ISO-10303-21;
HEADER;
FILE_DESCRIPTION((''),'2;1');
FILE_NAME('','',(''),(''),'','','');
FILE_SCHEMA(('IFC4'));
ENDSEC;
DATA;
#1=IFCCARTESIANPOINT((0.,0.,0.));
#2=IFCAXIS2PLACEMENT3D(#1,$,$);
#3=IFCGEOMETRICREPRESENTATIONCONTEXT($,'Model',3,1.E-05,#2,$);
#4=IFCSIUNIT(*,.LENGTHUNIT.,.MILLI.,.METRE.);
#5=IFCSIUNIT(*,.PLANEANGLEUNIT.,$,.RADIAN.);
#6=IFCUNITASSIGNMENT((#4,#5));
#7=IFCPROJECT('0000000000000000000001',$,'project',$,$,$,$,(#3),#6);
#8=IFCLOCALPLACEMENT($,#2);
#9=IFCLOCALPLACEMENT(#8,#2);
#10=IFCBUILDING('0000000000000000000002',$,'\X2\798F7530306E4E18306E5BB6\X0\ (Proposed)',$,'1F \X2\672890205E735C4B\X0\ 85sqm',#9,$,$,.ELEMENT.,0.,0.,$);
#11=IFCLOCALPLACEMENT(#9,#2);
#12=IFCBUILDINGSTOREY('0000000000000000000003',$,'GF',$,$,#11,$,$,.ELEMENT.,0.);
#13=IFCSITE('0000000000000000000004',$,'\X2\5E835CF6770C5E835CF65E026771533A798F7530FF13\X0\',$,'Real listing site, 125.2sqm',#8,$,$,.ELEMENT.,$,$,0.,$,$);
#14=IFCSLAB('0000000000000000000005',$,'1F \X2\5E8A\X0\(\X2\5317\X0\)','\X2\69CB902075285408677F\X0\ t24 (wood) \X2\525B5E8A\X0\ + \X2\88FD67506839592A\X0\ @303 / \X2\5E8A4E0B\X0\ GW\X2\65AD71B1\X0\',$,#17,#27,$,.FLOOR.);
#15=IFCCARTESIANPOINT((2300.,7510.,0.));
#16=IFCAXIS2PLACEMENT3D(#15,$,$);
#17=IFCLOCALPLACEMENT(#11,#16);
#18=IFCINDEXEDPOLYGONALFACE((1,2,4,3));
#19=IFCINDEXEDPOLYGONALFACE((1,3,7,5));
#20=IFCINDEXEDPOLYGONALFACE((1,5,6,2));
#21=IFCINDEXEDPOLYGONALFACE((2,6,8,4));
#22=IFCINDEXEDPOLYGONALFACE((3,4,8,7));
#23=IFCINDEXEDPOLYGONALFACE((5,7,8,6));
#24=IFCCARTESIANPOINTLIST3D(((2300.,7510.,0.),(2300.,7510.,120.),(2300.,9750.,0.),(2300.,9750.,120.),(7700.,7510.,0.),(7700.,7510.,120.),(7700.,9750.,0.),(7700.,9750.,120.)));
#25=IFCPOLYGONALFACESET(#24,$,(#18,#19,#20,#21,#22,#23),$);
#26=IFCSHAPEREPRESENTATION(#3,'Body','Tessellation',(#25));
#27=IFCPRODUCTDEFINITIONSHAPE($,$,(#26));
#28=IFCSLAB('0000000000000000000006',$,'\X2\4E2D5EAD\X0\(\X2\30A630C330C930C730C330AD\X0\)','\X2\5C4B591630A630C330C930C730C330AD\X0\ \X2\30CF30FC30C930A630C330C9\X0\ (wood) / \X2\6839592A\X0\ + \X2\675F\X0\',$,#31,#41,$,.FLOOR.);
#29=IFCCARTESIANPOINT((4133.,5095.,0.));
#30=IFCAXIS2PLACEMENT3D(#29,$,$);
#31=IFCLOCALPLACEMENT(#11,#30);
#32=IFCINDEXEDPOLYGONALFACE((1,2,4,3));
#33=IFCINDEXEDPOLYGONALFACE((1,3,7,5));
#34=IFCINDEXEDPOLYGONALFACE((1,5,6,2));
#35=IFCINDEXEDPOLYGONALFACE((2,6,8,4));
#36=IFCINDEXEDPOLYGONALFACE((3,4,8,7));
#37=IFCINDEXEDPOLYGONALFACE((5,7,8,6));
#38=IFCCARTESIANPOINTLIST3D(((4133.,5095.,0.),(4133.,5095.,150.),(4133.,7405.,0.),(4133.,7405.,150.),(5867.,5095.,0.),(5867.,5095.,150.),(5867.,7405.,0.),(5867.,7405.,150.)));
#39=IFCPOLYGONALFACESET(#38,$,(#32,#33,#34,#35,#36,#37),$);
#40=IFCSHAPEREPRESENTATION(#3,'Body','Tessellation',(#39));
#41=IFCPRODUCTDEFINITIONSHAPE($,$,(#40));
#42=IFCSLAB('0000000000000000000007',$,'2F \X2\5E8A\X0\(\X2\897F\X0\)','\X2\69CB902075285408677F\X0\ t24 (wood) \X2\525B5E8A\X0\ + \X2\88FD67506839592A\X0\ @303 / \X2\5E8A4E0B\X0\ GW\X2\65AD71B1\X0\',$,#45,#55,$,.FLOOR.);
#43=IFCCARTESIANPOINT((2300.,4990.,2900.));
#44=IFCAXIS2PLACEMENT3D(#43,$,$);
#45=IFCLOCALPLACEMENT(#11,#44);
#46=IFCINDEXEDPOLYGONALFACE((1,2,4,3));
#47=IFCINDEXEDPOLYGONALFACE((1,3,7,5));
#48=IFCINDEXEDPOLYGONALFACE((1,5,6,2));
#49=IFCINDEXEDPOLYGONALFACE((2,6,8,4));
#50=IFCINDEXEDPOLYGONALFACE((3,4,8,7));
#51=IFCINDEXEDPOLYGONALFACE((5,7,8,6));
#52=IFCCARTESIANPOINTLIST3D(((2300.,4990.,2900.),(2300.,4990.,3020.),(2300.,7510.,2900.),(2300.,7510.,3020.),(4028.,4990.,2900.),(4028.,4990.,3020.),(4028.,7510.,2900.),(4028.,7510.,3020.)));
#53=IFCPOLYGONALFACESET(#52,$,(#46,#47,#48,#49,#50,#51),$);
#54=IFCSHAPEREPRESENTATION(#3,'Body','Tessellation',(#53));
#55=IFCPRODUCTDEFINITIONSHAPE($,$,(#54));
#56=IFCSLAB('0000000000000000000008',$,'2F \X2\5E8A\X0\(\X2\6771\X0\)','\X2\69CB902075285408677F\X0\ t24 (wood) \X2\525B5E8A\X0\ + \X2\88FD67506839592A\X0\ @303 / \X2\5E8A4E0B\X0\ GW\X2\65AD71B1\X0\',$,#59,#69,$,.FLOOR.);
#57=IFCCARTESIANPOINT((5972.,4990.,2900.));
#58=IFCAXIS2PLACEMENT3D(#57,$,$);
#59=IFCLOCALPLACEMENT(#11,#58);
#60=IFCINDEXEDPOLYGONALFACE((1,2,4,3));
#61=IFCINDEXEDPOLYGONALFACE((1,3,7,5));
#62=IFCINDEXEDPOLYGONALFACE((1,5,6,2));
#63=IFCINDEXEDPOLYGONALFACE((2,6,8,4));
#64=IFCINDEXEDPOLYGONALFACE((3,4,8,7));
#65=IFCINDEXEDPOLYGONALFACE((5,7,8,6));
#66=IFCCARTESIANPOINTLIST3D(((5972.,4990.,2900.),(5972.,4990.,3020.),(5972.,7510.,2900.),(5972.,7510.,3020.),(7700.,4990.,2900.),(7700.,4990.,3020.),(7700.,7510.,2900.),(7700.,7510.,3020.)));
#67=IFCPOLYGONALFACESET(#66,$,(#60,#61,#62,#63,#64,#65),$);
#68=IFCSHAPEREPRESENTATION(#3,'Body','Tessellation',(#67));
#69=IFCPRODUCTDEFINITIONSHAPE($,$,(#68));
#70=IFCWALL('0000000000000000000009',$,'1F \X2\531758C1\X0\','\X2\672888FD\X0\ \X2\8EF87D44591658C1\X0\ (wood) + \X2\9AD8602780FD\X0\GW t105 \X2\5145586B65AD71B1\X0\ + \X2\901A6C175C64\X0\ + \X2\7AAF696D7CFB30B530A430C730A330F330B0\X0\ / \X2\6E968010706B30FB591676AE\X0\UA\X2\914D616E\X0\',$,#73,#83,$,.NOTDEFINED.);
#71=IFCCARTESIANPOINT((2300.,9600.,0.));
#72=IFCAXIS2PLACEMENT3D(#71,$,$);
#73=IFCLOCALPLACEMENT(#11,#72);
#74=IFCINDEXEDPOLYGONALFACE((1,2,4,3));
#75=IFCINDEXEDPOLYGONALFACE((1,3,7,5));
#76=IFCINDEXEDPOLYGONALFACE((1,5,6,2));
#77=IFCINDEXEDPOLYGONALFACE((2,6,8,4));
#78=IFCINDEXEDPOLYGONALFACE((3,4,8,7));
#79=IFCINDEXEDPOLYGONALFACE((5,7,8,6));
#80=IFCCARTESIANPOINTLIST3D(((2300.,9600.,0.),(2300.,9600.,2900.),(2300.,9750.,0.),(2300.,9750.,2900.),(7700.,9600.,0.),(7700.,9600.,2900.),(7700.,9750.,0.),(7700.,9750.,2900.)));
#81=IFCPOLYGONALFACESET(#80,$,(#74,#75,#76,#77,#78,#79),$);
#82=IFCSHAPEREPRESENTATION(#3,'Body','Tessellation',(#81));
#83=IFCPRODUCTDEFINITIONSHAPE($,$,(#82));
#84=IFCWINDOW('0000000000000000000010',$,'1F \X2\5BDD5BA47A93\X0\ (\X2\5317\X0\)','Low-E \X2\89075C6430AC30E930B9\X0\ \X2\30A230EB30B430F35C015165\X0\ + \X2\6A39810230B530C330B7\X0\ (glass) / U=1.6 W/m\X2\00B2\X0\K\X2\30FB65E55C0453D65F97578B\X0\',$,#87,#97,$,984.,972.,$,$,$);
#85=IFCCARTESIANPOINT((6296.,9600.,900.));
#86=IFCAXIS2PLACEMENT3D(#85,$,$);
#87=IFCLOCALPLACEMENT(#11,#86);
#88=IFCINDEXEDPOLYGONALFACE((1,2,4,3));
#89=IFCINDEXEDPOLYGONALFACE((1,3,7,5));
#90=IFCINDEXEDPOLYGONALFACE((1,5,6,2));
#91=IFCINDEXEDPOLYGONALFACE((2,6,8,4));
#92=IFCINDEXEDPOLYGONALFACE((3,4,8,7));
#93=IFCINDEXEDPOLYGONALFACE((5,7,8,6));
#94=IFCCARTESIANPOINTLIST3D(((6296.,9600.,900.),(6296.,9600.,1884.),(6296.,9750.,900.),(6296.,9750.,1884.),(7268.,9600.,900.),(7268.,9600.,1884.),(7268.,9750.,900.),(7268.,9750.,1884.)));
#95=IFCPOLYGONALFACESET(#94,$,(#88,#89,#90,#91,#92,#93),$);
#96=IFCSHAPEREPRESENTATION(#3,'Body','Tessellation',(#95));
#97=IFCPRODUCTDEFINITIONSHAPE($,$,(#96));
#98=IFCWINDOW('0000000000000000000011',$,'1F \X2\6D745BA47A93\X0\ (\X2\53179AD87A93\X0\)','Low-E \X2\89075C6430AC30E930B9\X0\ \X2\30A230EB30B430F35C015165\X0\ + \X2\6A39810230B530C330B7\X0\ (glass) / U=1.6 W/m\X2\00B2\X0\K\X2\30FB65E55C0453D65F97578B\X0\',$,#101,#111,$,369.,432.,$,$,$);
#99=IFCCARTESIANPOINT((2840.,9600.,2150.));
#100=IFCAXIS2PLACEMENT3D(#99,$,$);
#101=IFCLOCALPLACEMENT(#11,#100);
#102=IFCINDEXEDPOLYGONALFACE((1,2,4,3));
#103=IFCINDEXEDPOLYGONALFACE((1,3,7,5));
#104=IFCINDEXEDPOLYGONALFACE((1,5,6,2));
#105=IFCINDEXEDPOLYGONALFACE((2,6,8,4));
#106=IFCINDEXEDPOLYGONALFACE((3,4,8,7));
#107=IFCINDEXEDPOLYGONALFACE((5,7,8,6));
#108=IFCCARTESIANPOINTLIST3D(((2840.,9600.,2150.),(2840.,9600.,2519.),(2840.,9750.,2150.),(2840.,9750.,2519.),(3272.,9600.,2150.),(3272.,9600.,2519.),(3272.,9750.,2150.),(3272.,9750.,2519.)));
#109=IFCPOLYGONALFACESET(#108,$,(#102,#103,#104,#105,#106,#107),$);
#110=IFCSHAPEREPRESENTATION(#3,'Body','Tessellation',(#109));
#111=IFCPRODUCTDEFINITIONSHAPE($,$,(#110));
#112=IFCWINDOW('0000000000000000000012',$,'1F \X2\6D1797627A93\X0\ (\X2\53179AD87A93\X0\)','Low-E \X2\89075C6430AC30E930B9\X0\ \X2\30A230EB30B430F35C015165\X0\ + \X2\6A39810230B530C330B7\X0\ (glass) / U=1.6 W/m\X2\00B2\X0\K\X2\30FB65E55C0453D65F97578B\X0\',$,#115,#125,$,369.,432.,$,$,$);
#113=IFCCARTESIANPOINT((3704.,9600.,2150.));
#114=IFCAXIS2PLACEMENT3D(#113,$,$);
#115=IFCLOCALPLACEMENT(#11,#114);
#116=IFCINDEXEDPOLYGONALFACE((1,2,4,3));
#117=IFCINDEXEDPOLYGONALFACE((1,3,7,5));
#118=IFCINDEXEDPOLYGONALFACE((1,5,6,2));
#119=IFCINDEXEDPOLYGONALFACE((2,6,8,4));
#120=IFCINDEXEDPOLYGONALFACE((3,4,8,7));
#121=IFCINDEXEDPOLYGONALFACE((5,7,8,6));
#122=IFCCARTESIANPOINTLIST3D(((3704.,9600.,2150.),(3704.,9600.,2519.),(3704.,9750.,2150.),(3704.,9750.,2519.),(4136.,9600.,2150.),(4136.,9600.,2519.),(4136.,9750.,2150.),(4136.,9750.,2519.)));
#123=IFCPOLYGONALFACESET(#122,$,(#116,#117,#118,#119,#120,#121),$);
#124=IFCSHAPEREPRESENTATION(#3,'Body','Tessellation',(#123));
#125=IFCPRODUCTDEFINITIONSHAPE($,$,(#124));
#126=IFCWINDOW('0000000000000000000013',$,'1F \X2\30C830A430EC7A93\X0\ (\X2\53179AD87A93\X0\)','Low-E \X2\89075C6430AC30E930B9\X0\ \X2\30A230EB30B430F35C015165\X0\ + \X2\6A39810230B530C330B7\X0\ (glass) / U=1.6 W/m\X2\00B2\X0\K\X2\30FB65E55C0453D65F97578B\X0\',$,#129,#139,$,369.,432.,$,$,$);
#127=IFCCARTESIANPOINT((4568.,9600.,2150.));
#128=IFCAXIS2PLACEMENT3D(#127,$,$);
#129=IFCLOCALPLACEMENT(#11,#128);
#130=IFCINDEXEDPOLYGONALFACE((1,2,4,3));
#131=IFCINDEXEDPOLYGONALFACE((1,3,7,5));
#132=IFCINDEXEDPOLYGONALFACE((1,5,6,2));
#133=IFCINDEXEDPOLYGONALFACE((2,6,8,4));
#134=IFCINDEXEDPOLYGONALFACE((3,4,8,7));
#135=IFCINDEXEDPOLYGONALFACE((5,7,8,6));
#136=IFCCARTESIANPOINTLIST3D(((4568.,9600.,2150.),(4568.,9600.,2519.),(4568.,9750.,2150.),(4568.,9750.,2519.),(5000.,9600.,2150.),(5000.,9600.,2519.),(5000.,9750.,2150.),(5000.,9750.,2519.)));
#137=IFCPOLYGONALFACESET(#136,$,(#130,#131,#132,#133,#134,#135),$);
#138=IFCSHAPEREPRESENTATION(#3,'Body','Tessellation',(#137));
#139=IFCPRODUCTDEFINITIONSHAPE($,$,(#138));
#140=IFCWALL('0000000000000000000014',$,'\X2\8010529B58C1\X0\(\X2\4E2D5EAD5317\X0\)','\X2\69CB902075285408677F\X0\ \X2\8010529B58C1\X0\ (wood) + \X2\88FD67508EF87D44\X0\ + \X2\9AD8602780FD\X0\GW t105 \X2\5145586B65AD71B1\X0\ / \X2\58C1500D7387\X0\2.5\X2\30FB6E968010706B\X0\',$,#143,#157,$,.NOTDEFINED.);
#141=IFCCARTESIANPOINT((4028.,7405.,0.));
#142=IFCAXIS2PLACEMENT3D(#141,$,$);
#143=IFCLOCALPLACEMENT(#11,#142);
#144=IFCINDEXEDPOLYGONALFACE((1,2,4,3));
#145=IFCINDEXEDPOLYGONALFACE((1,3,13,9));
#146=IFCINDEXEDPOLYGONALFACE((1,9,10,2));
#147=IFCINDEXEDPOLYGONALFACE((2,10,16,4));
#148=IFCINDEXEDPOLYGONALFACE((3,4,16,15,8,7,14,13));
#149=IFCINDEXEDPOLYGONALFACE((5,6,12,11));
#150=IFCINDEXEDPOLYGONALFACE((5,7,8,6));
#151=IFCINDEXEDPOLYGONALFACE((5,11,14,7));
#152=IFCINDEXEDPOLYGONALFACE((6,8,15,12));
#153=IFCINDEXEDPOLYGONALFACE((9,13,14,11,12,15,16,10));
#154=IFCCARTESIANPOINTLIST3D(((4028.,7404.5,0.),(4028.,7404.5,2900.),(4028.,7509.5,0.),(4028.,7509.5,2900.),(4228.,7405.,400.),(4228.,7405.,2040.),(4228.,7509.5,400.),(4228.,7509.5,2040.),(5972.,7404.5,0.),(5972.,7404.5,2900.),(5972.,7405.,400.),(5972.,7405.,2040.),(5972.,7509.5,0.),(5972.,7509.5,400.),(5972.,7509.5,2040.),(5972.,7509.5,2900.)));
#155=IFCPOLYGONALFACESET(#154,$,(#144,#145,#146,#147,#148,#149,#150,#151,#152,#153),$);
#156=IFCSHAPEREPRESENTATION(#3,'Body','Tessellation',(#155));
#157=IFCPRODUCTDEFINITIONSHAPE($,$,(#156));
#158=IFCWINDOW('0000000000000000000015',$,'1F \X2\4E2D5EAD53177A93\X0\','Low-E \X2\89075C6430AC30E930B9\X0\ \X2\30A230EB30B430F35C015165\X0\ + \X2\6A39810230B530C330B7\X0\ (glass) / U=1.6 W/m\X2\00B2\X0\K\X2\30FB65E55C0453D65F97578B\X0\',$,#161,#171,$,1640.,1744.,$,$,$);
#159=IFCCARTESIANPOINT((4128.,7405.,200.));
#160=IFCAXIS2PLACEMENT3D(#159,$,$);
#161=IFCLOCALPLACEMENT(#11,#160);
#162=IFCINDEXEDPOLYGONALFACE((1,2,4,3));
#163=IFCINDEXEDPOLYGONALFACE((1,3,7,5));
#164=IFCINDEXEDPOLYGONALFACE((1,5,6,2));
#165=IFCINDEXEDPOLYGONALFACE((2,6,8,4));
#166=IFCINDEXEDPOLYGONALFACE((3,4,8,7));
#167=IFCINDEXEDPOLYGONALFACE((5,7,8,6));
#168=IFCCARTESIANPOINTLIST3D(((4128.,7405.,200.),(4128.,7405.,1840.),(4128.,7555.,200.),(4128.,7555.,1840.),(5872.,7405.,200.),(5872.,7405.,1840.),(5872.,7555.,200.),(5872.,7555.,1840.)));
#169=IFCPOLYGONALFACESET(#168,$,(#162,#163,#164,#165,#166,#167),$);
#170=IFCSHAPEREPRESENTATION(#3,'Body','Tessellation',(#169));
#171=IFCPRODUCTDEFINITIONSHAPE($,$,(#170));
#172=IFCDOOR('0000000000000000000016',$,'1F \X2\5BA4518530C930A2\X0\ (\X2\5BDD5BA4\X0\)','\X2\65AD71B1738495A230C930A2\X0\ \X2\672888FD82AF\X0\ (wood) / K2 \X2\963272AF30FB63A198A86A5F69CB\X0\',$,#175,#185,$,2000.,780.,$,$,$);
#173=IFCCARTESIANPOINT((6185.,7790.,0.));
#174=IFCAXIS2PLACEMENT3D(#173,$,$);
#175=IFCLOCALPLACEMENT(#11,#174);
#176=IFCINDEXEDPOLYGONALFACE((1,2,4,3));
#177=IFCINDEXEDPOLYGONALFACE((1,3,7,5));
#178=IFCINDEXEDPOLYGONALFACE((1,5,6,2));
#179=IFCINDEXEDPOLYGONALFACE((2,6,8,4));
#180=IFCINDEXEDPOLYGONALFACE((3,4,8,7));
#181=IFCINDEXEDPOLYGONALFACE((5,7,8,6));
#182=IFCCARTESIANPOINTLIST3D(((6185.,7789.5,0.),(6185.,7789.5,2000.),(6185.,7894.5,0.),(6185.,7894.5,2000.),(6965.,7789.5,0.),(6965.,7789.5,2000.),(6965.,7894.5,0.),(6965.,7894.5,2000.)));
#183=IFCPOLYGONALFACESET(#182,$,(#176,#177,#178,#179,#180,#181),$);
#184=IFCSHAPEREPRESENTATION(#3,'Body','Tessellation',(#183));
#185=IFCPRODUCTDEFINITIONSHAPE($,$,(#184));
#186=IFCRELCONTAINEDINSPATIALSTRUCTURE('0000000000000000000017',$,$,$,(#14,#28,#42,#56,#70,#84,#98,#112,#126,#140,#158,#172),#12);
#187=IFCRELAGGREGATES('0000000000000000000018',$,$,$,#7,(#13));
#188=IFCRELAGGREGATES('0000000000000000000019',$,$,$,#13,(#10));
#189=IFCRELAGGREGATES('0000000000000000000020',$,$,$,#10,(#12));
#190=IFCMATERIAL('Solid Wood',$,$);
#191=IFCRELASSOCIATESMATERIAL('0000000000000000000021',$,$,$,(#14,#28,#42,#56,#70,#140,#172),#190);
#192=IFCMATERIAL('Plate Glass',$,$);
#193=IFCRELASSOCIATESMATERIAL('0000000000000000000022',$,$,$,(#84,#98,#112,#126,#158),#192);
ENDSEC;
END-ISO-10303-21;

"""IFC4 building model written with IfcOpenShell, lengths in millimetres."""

from ifc_helpers import new_model, si_unit, frame, frame_2d, origin, place, context, project, spatial, rectangle, extrude, material, element, fill, save


model = new_model("IFC4")

# Units and contexts
model_context = context("Model", 3, precision=1e-05, world=origin())
ifc_project = project(units=[si_unit("LENGTHUNIT", "METRE", prefix="MILLI"), si_unit("PLANEANGLEUNIT", "RADIAN")], contexts=[model_context])

# Site, building, storey
site_placement = place(None, origin())
site = spatial("IfcSite", under=ifc_project, at=site_placement, Name="広島県広島市東区福田３", ObjectType="Real listing site, 125.2sqm", CompositionType="ELEMENT", RefElevation=0.0)
building_placement = place(site_placement, origin())
building = spatial("IfcBuilding", under=site, at=building_placement, Name="福田の丘の家 (Proposed)", ObjectType="1F 木造平屋 85sqm", CompositionType="ELEMENT", ElevationOfRefHeight=0.0, ElevationOfTerrain=0.0)
storey_placement = place(building_placement, origin())
storey = spatial("IfcBuildingStorey", under=building, at=storey_placement, Name="GF", CompositionType="ELEMENT", Elevation=0.0)

# Slabs
ifc_material_1 = material(Name="Solid Wood")
slab_1_placement = place(storey_placement, frame((2300.0, 7510.0, 0.0)))
element("IfcSlab", 1, at=slab_1_placement, inside=storey, material=ifc_material_1, Name="1F 床(北)", Description="構造用合板 t24 (wood) 剛床 + 製材根太 @303 / 床下 GW断熱", PredefinedType="FLOOR", context=model_context, shape_type="SweptSolid", body=[
    extrude(rectangle(XDim=5400.0, YDim=2240.0, at=frame_2d((2700.0, 1120.0))), frame((2300.0, 7510.0, 0.0)), (0.0, 0.0, 1.0), 120.0),
])
slab_2_placement = place(storey_placement, frame((4133.0, 5095.0, 0.0)))
element("IfcSlab", 2, at=slab_2_placement, inside=storey, material=ifc_material_1, Name="中庭(ウッドデッキ)", Description="屋外ウッドデッキ ハードウッド (wood) / 根太 + 束", PredefinedType="FLOOR", context=model_context, shape_type="SweptSolid", body=[
    extrude(rectangle(XDim=1734.0, YDim=2310.0, at=frame_2d((867.0, 1155.0))), frame((4133.0, 5095.0, 0.0)), (0.0, 0.0, 1.0), 150.0),
])
slab_3_placement = place(storey_placement, frame((2300.0, 4990.0, 2900.0)))
element("IfcSlab", 3, at=slab_3_placement, inside=storey, material=ifc_material_1, Name="2F 床(西)", Description="構造用合板 t24 (wood) 剛床 + 製材根太 @303 / 床下 GW断熱", PredefinedType="FLOOR", context=model_context, shape_type="SweptSolid", body=[
    extrude(rectangle(XDim=1728.0, YDim=2520.0, at=frame_2d((864.0, 1260.0))), frame((2300.0, 4990.0, 2900.0)), (0.0, 0.0, 1.0), 120.0),
])
slab_4_placement = place(storey_placement, frame((5972.0, 4990.0, 2900.0)))
element("IfcSlab", 4, at=slab_4_placement, inside=storey, material=ifc_material_1, Name="2F 床(東)", Description="構造用合板 t24 (wood) 剛床 + 製材根太 @303 / 床下 GW断熱", PredefinedType="FLOOR", context=model_context, shape_type="SweptSolid", body=[
    extrude(rectangle(XDim=1728.0, YDim=2520.0, at=frame_2d((864.0, 1260.0))), frame((5972.0, 4990.0, 2900.0)), (0.0, 0.0, 1.0), 120.0),
])

# Wall, openings, windows
wall_1_placement = place(storey_placement, frame((2300.0, 9600.0, 0.0)))
wall_1 = element("IfcWall", 5, at=wall_1_placement, inside=storey, material=ifc_material_1, Name="1F 北壁", Description="木製 軸組外壁 (wood) + 高性能GW t105 充填断熱 + 通気層 + 窯業系サイディング / 準耐火・外皮UA配慮", PredefinedType="NOTDEFINED", context=model_context, shape_type="SweptSolid", body=[
    extrude(rectangle(XDim=5400.0, YDim=150.0, at=frame_2d((2700.0, 75.0))), frame((2300.0, 9600.0, 0.0)), (0.0, 0.0, 1.0), 2900.0),
])
opening_1_placement = place(storey_placement, frame((6296.0, 9600.0, 900.0)))
opening_1 = element("IfcOpeningElement", 6, at=opening_1_placement, cuts=wall_1, PredefinedType="NOTDEFINED", context=model_context, shape_type="SweptSolid", body=[
    extrude(rectangle(XDim=972.0, YDim=150.0, at=frame_2d((486.0, 75.0))), frame((6296.0, 9600.0, 900.0)), (0.0, 0.0, 1.0), 984.0),
])
opening_2_placement = place(storey_placement, frame((2840.0, 9600.0, 2150.0)))
opening_2 = element("IfcOpeningElement", 7, at=opening_2_placement, cuts=wall_1, PredefinedType="NOTDEFINED", context=model_context, shape_type="SweptSolid", body=[
    extrude(rectangle(XDim=432.0, YDim=150.0, at=frame_2d((216.0, 75.0))), frame((2840.0, 9600.0, 2150.0)), (0.0, 0.0, 1.0), 369.0),
])
opening_3_placement = place(storey_placement, frame((3704.0, 9600.0, 2150.0)))
opening_3 = element("IfcOpeningElement", 8, at=opening_3_placement, cuts=wall_1, PredefinedType="NOTDEFINED", context=model_context, shape_type="SweptSolid", body=[
    extrude(rectangle(XDim=432.0, YDim=150.0, at=frame_2d((216.0, 75.0))), frame((3704.0, 9600.0, 2150.0)), (0.0, 0.0, 1.0), 369.0),
])
opening_4_placement = place(storey_placement, frame((4568.0, 9600.0, 2150.0)))
opening_4 = element("IfcOpeningElement", 9, at=opening_4_placement, cuts=wall_1, PredefinedType="NOTDEFINED", context=model_context, shape_type="SweptSolid", body=[
    extrude(rectangle(XDim=432.0, YDim=150.0, at=frame_2d((216.0, 75.0))), frame((4568.0, 9600.0, 2150.0)), (0.0, 0.0, 1.0), 369.0),
])
ifc_material_2 = material(Name="Plate Glass")
window_1_placement = place(storey_placement, frame((6296.0, 9600.0, 900.0)))
window_1 = element("IfcWindow", 10, at=window_1_placement, inside=storey, material=ifc_material_2, Name="1F 寝室窓 (北)", Description="Low-E 複層ガラス アルゴン封入 + 樹脂サッシ (glass) / U=1.6 W/m²K・日射取得型", OverallHeight=984.0, OverallWidth=972.0, context=model_context, shape_type="SweptSolid", body=[
    extrude(rectangle(XDim=972.0, YDim=150.0, at=frame_2d((486.0, 75.0))), frame((6296.0, 9600.0, 900.0)), (0.0, 0.0, 1.0), 984.0),
])
fill(opening_1, window_1)
window_2_placement = place(storey_placement, frame((2840.0, 9600.0, 2150.0)))
window_2 = element("IfcWindow", 11, at=window_2_placement, inside=storey, material=ifc_material_2, Name="1F 浴室窓 (北高窓)", Description="Low-E 複層ガラス アルゴン封入 + 樹脂サッシ (glass) / U=1.6 W/m²K・日射取得型", OverallHeight=369.0, OverallWidth=432.0, context=model_context, shape_type="SweptSolid", body=[
    extrude(rectangle(XDim=432.0, YDim=150.0, at=frame_2d((216.0, 75.0))), frame((2840.0, 9600.0, 2150.0)), (0.0, 0.0, 1.0), 369.0),
])
fill(opening_2, window_2)
window_3_placement = place(storey_placement, frame((3704.0, 9600.0, 2150.0)))
window_3 = element("IfcWindow", 12, at=window_3_placement, inside=storey, material=ifc_material_2, Name="1F 洗面窓 (北高窓)", Description="Low-E 複層ガラス アルゴン封入 + 樹脂サッシ (glass) / U=1.6 W/m²K・日射取得型", OverallHeight=369.0, OverallWidth=432.0, context=model_context, shape_type="SweptSolid", body=[
    extrude(rectangle(XDim=432.0, YDim=150.0, at=frame_2d((216.0, 75.0))), frame((3704.0, 9600.0, 2150.0)), (0.0, 0.0, 1.0), 369.0),
])
fill(opening_3, window_3)
window_4_placement = place(storey_placement, frame((4568.0, 9600.0, 2150.0)))
window_4 = element("IfcWindow", 13, at=window_4_placement, inside=storey, material=ifc_material_2, Name="1F トイレ窓 (北高窓)", Description="Low-E 複層ガラス アルゴン封入 + 樹脂サッシ (glass) / U=1.6 W/m²K・日射取得型", OverallHeight=369.0, OverallWidth=432.0, context=model_context, shape_type="SweptSolid", body=[
    extrude(rectangle(XDim=432.0, YDim=150.0, at=frame_2d((216.0, 75.0))), frame((4568.0, 9600.0, 2150.0)), (0.0, 0.0, 1.0), 369.0),
])
fill(opening_4, window_4)

# Wall, opening, window
wall_2_placement = place(storey_placement, frame((4028.0, 7405.0, 0.0)))
wall_2 = element("IfcWall", 14, at=wall_2_placement, inside=storey, material=ifc_material_1, Name="耐力壁(中庭北)", Description="構造用合板 耐力壁 (wood) + 製材軸組 + 高性能GW t105 充填断熱 / 壁倍率2.5・準耐火", PredefinedType="NOTDEFINED", context=model_context, shape_type="SweptSolid", body=[
    extrude(rectangle(XDim=1944.0, YDim=105.0, at=frame_2d((972.0, 52.0))), frame((4028.0, 7405.0, 0.0)), (0.0, 0.0, 1.0), 2900.0),
])
opening_5_placement = place(storey_placement, frame((4128.0, 7405.0, 200.0)))
opening_5 = element("IfcOpeningElement", 15, at=opening_5_placement, cuts=wall_2, PredefinedType="NOTDEFINED", context=model_context, shape_type="SweptSolid", body=[
    extrude(rectangle(XDim=1744.0, YDim=150.0, at=frame_2d((872.0, 75.0))), frame((4128.0, 7405.0, 200.0)), (0.0, 0.0, 1.0), 1640.0),
])
window_5_placement = place(storey_placement, frame((4128.0, 7405.0, 200.0)))
window_5 = element("IfcWindow", 16, at=window_5_placement, inside=storey, material=ifc_material_2, Name="1F 中庭北窓", Description="Low-E 複層ガラス アルゴン封入 + 樹脂サッシ (glass) / U=1.6 W/m²K・日射取得型", OverallHeight=1640.0, OverallWidth=1744.0, context=model_context, shape_type="SweptSolid", body=[
    extrude(rectangle(XDim=1744.0, YDim=150.0, at=frame_2d((872.0, 75.0))), frame((4128.0, 7405.0, 200.0)), (0.0, 0.0, 1.0), 1640.0),
])
fill(opening_5, window_5)

# Door
door_1_placement = place(storey_placement, frame((6185.0, 7790.0, 0.0)))
element("IfcDoor", 17, at=door_1_placement, inside=storey, material=ifc_material_1, Name="1F 室内ドア (寝室)", Description="断熱玄関ドア 木製芯 (wood) / K2 防犯・採風機構", OverallHeight=2000.0, OverallWidth=780.0, context=model_context, shape_type="SweptSolid", body=[
    extrude(rectangle(XDim=780.0, YDim=105.0, at=frame_2d((390.0, 52.0))), frame((6185.0, 7790.0, 0.0)), (0.0, 0.0, 1.0), 2000.0),
])

save(model, "model.ifc")
